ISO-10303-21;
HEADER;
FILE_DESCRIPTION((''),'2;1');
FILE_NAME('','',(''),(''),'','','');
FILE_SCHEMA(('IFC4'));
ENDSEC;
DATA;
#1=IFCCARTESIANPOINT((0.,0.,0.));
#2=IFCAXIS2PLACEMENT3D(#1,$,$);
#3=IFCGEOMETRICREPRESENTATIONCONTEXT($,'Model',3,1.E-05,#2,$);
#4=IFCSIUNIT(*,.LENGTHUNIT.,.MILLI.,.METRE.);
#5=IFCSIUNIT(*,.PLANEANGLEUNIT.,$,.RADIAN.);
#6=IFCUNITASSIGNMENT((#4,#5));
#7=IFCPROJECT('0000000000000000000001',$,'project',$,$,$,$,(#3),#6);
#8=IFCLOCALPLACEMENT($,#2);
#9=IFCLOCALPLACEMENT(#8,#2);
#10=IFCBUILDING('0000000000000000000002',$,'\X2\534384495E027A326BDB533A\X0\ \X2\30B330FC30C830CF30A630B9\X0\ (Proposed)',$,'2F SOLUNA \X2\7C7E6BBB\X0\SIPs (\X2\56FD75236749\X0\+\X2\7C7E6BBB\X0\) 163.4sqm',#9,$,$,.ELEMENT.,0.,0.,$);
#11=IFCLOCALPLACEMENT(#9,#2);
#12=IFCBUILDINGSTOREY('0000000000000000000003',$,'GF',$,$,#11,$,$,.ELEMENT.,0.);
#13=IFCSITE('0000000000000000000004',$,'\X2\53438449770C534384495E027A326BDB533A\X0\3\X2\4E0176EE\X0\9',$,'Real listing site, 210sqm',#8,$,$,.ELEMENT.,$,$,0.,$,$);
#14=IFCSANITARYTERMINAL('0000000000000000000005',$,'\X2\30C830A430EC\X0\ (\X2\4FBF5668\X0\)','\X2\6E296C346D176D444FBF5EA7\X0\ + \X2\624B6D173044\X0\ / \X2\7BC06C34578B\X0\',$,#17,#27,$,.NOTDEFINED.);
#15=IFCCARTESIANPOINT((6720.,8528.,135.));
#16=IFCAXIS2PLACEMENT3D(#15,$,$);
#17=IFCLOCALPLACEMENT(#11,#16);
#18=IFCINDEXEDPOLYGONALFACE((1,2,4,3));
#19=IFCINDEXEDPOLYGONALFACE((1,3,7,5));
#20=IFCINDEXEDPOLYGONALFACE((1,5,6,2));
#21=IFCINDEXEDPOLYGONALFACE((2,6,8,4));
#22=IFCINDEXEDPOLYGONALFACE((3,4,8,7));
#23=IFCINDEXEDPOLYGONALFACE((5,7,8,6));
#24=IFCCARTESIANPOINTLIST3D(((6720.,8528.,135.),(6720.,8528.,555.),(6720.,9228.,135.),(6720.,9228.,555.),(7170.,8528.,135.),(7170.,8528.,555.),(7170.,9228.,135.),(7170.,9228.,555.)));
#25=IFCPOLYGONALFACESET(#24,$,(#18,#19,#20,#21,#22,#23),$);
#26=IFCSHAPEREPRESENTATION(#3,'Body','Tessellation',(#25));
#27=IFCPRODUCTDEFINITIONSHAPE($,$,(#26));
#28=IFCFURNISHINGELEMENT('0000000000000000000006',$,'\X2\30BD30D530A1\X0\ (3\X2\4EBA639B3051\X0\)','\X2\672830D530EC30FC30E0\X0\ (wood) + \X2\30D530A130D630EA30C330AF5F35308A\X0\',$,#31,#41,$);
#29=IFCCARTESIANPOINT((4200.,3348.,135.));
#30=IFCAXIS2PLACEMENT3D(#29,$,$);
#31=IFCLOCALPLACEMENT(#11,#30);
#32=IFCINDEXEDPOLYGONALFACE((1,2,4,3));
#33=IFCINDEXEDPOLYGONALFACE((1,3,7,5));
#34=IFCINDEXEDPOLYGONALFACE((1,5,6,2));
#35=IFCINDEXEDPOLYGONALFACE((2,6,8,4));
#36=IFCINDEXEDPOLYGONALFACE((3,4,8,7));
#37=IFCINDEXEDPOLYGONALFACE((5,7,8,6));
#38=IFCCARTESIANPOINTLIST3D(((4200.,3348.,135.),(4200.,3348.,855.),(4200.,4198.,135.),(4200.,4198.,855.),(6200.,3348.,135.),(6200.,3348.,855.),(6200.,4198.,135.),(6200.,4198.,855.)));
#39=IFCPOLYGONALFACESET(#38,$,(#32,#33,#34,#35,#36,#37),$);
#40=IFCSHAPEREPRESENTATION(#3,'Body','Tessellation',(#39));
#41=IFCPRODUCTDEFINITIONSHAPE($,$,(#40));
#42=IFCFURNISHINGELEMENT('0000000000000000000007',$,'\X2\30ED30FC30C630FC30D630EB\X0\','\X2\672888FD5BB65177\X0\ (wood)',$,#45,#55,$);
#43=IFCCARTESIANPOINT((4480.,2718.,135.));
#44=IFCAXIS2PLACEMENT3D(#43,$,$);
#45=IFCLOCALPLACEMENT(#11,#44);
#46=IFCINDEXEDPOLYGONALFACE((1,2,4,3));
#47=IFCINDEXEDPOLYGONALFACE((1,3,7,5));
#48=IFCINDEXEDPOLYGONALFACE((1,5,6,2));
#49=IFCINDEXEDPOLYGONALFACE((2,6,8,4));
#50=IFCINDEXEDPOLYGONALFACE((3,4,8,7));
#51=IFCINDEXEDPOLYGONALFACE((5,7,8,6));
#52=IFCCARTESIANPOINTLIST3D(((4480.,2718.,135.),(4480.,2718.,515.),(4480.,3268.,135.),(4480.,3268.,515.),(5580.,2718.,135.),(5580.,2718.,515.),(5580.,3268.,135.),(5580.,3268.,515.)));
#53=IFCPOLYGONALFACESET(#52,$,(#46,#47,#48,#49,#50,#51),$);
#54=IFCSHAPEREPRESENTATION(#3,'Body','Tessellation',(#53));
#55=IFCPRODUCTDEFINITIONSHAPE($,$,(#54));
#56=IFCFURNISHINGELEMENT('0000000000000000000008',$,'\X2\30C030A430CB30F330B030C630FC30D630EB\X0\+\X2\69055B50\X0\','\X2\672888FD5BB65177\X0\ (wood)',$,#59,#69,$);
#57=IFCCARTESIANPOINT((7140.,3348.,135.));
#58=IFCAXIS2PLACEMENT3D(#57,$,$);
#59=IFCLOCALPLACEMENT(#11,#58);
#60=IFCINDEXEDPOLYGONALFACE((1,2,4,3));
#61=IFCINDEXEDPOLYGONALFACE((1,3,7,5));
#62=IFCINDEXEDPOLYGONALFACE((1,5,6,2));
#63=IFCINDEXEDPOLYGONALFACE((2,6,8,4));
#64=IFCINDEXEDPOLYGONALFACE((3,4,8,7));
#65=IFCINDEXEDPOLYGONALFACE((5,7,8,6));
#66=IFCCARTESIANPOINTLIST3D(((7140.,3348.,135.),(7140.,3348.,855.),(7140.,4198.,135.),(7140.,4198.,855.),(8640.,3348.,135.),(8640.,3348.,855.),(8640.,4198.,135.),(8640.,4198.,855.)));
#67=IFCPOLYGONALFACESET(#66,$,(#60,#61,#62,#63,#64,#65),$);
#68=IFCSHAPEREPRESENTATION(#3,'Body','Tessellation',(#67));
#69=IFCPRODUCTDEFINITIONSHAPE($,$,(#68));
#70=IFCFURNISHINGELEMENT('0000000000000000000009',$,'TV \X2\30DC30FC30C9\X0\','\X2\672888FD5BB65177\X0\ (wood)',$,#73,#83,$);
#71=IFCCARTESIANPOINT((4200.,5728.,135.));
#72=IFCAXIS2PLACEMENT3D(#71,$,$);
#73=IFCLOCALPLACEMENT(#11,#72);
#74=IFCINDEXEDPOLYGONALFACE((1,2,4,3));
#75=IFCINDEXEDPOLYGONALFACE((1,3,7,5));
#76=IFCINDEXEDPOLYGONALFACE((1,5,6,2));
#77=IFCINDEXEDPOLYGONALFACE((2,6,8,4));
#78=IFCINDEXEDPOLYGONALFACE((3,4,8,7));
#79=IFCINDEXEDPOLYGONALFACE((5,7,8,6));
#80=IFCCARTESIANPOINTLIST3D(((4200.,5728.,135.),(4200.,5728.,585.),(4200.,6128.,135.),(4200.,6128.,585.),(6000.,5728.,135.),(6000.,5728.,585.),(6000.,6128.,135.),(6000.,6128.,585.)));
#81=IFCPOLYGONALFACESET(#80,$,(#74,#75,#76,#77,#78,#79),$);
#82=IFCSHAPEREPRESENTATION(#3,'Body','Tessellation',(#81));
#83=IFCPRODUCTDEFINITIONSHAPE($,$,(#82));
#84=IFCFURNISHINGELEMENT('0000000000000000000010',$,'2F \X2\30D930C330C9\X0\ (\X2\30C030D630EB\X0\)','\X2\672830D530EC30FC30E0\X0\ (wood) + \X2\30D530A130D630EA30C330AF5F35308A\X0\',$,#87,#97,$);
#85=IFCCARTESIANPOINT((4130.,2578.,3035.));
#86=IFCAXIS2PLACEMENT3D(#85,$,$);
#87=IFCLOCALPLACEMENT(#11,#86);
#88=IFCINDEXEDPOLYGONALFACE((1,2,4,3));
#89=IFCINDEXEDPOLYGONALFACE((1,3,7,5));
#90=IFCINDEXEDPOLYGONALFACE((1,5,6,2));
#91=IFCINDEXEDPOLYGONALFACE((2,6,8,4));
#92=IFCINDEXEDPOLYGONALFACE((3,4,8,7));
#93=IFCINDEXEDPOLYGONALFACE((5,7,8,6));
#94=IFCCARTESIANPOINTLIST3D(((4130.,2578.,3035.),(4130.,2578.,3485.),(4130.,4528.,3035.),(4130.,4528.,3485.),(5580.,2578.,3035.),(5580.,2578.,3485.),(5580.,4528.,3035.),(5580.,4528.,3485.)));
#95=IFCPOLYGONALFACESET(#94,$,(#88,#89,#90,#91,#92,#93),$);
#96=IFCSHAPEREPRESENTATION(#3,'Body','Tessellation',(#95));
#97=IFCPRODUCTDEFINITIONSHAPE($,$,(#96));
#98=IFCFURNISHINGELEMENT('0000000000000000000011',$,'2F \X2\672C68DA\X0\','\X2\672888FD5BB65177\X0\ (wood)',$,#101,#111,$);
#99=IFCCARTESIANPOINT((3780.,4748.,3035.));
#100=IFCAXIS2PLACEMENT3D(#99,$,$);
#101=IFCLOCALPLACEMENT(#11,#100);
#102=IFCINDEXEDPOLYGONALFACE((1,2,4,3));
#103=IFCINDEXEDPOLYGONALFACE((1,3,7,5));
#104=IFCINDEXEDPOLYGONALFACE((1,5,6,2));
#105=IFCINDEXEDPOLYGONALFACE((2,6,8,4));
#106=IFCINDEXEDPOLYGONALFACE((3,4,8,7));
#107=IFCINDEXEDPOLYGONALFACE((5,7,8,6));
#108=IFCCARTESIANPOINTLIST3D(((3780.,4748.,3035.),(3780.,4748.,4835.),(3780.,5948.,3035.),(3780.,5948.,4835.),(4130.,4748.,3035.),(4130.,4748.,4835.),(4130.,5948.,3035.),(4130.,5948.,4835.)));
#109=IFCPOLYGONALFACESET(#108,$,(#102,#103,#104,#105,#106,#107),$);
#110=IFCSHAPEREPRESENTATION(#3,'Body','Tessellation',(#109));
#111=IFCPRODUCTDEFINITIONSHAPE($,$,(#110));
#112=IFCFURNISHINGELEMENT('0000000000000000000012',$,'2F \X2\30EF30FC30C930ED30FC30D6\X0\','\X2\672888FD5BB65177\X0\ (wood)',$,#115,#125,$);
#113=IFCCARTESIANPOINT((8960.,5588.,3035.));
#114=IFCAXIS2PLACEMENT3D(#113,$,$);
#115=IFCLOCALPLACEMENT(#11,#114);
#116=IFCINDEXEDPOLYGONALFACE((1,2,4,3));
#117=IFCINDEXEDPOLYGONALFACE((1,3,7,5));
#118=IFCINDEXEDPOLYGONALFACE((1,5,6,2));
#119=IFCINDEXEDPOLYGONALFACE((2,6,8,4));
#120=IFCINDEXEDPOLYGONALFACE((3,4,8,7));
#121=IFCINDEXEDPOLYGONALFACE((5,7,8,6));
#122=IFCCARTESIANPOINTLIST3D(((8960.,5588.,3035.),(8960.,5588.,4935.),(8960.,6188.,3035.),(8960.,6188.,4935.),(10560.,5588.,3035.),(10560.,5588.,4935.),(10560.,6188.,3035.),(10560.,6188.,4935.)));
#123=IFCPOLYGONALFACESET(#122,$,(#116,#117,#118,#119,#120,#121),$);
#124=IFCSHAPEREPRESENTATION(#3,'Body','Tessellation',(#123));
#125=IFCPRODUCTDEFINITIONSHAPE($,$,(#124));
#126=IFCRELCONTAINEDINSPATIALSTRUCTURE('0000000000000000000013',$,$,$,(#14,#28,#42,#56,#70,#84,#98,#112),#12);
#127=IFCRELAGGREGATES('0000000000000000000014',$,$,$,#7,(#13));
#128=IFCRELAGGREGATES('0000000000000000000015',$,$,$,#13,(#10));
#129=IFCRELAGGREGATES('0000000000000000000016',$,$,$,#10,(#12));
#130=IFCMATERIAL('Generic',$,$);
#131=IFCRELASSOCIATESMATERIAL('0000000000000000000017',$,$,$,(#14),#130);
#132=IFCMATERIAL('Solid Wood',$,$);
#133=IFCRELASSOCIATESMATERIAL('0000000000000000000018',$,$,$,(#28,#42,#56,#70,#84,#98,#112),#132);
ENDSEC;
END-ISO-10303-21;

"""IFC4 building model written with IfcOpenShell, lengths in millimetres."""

from ifc_helpers import new_model, si_unit, frame, frame_2d, origin, place, context, project, spatial, rectangle, extrude, material, element, save


model = new_model("IFC4")

# Units and contexts
model_context = context("Model", 3, precision=1e-05, world=origin())
ifc_project = project(units=[si_unit("LENGTHUNIT", "METRE", prefix="MILLI"), si_unit("PLANEANGLEUNIT", "RADIAN")], contexts=[model_context])

# Site, building, storey
site_placement = place(None, origin())
site = spatial("IfcSite", under=ifc_project, at=site_placement, Name="千葉県千葉市稲毛区3丁目9", ObjectType="Real listing site, 210sqm", CompositionType="ELEMENT", RefElevation=0.0)
building_placement = place(site_placement, origin())
building = spatial("IfcBuilding", under=site, at=building_placement, Name="千葉市稲毛区 コートハウス (Proposed)", ObjectType="2F SOLUNA 籾殻SIPs (国産杉+籾殻) 163.4sqm", CompositionType="ELEMENT", ElevationOfRefHeight=0.0, ElevationOfTerrain=0.0)
storey_placement = place(building_placement, origin())
storey = spatial("IfcBuildingStorey", under=building, at=storey_placement, Name="GF", CompositionType="ELEMENT", Elevation=0.0)

# Shared definitions
ifc_material_1 = material(Name="Solid Wood")

# Shared definitions
ifc_material_2 = material(Name="Generic")

# Sanitary terminal
sanitary_terminal_1_placement = place(storey_placement, frame((6720.0, 8528.0, 135.0)))
element("IfcSanitaryTerminal", 1, at=sanitary_terminal_1_placement, inside=storey, material=ifc_material_2, Name="トイレ (便器)", Description="温水洗浄便座 + 手洗い / 節水型", PredefinedType="NOTDEFINED", context=model_context, shape_type="SweptSolid", body=[
    extrude(rectangle(XDim=450.0, YDim=700.0, at=frame_2d((225.0, 350.0))), frame((6720.0, 8528.0, 135.0)), (0.0, 0.0, 1.0), 420.0),
])

# Furnishing elements
furnishing_1_placement = place(storey_placement, frame((4200.0, 3348.0, 135.0)))
element("IfcFurnishingElement", 2, at=furnishing_1_placement, inside=storey, material=ifc_material_1, Name="ソファ (3人掛け)", Description="木フレーム (wood) + ファブリック張り", context=model_context, shape_type="SweptSolid", body=[
    extrude(rectangle(XDim=2000.0, YDim=850.0, at=frame_2d((1000.0, 425.0))), frame((4200.0, 3348.0, 135.0)), (0.0, 0.0, 1.0), 720.0),
])
furnishing_2_placement = place(storey_placement, frame((4480.0, 2718.0, 135.0)))
element("IfcFurnishingElement", 3, at=furnishing_2_placement, inside=storey, material=ifc_material_1, Name="ローテーブル", Description="木製家具 (wood)", context=model_context, shape_type="SweptSolid", body=[
    extrude(rectangle(XDim=1100.0, YDim=550.0, at=frame_2d((550.0, 275.0))), frame((4480.0, 2718.0, 135.0)), (0.0, 0.0, 1.0), 380.0),
])
furnishing_3_placement = place(storey_placement, frame((7140.0, 3348.0, 135.0)))
element("IfcFurnishingElement", 4, at=furnishing_3_placement, inside=storey, material=ifc_material_1, Name="ダイニングテーブル+椅子", Description="木製家具 (wood)", context=model_context, shape_type="SweptSolid", body=[
    extrude(rectangle(XDim=1500.0, YDim=850.0, at=frame_2d((750.0, 425.0))), frame((7140.0, 3348.0, 135.0)), (0.0, 0.0, 1.0), 720.0),
])
furnishing_4_placement = place(storey_placement, frame((4200.0, 5728.0, 135.0)))
element("IfcFurnishingElement", 5, at=furnishing_4_placement, inside=storey, material=ifc_material_1, Name="TV ボード", Description="木製家具 (wood)", context=model_context, shape_type="SweptSolid", body=[
    extrude(rectangle(XDim=1800.0, YDim=400.0, at=frame_2d((900.0, 200.0))), frame((4200.0, 5728.0, 135.0)), (0.0, 0.0, 1.0), 450.0),
])
furnishing_5_placement = place(storey_placement, frame((4130.0, 2578.0, 3035.0)))
element("IfcFurnishingElement", 6, at=furnishing_5_placement, inside=storey, material=ifc_material_1, Name="2F ベッド (ダブル)", Description="木フレーム (wood) + ファブリック張り", context=model_context, shape_type="SweptSolid", body=[
    extrude(rectangle(XDim=1450.0, YDim=1950.0, at=frame_2d((725.0, 975.0))), frame((4130.0, 2578.0, 3035.0)), (0.0, 0.0, 1.0), 450.0),
])
furnishing_6_placement = place(storey_placement, frame((3780.0, 4748.0, 3035.0)))
element("IfcFurnishingElement", 7, at=furnishing_6_placement, inside=storey, material=ifc_material_1, Name="2F 本棚", Description="木製家具 (wood)", context=model_context, shape_type="SweptSolid", body=[
    extrude(rectangle(XDim=350.0, YDim=1200.0, at=frame_2d((175.0, 600.0))), frame((3780.0, 4748.0, 3035.0)), (0.0, 0.0, 1.0), 1800.0),
])
furnishing_7_placement = place(storey_placement, frame((8960.0, 5588.0, 3035.0)))
element("IfcFurnishingElement", 8, at=furnishing_7_placement, inside=storey, material=ifc_material_1, Name="2F ワードローブ", Description="木製家具 (wood)", context=model_context, shape_type="SweptSolid", body=[
    extrude(rectangle(XDim=1600.0, YDim=600.0, at=frame_2d((800.0, 300.0))), frame((8960.0, 5588.0, 3035.0)), (0.0, 0.0, 1.0), 1900.0),
])

save(model, "model.ifc")
